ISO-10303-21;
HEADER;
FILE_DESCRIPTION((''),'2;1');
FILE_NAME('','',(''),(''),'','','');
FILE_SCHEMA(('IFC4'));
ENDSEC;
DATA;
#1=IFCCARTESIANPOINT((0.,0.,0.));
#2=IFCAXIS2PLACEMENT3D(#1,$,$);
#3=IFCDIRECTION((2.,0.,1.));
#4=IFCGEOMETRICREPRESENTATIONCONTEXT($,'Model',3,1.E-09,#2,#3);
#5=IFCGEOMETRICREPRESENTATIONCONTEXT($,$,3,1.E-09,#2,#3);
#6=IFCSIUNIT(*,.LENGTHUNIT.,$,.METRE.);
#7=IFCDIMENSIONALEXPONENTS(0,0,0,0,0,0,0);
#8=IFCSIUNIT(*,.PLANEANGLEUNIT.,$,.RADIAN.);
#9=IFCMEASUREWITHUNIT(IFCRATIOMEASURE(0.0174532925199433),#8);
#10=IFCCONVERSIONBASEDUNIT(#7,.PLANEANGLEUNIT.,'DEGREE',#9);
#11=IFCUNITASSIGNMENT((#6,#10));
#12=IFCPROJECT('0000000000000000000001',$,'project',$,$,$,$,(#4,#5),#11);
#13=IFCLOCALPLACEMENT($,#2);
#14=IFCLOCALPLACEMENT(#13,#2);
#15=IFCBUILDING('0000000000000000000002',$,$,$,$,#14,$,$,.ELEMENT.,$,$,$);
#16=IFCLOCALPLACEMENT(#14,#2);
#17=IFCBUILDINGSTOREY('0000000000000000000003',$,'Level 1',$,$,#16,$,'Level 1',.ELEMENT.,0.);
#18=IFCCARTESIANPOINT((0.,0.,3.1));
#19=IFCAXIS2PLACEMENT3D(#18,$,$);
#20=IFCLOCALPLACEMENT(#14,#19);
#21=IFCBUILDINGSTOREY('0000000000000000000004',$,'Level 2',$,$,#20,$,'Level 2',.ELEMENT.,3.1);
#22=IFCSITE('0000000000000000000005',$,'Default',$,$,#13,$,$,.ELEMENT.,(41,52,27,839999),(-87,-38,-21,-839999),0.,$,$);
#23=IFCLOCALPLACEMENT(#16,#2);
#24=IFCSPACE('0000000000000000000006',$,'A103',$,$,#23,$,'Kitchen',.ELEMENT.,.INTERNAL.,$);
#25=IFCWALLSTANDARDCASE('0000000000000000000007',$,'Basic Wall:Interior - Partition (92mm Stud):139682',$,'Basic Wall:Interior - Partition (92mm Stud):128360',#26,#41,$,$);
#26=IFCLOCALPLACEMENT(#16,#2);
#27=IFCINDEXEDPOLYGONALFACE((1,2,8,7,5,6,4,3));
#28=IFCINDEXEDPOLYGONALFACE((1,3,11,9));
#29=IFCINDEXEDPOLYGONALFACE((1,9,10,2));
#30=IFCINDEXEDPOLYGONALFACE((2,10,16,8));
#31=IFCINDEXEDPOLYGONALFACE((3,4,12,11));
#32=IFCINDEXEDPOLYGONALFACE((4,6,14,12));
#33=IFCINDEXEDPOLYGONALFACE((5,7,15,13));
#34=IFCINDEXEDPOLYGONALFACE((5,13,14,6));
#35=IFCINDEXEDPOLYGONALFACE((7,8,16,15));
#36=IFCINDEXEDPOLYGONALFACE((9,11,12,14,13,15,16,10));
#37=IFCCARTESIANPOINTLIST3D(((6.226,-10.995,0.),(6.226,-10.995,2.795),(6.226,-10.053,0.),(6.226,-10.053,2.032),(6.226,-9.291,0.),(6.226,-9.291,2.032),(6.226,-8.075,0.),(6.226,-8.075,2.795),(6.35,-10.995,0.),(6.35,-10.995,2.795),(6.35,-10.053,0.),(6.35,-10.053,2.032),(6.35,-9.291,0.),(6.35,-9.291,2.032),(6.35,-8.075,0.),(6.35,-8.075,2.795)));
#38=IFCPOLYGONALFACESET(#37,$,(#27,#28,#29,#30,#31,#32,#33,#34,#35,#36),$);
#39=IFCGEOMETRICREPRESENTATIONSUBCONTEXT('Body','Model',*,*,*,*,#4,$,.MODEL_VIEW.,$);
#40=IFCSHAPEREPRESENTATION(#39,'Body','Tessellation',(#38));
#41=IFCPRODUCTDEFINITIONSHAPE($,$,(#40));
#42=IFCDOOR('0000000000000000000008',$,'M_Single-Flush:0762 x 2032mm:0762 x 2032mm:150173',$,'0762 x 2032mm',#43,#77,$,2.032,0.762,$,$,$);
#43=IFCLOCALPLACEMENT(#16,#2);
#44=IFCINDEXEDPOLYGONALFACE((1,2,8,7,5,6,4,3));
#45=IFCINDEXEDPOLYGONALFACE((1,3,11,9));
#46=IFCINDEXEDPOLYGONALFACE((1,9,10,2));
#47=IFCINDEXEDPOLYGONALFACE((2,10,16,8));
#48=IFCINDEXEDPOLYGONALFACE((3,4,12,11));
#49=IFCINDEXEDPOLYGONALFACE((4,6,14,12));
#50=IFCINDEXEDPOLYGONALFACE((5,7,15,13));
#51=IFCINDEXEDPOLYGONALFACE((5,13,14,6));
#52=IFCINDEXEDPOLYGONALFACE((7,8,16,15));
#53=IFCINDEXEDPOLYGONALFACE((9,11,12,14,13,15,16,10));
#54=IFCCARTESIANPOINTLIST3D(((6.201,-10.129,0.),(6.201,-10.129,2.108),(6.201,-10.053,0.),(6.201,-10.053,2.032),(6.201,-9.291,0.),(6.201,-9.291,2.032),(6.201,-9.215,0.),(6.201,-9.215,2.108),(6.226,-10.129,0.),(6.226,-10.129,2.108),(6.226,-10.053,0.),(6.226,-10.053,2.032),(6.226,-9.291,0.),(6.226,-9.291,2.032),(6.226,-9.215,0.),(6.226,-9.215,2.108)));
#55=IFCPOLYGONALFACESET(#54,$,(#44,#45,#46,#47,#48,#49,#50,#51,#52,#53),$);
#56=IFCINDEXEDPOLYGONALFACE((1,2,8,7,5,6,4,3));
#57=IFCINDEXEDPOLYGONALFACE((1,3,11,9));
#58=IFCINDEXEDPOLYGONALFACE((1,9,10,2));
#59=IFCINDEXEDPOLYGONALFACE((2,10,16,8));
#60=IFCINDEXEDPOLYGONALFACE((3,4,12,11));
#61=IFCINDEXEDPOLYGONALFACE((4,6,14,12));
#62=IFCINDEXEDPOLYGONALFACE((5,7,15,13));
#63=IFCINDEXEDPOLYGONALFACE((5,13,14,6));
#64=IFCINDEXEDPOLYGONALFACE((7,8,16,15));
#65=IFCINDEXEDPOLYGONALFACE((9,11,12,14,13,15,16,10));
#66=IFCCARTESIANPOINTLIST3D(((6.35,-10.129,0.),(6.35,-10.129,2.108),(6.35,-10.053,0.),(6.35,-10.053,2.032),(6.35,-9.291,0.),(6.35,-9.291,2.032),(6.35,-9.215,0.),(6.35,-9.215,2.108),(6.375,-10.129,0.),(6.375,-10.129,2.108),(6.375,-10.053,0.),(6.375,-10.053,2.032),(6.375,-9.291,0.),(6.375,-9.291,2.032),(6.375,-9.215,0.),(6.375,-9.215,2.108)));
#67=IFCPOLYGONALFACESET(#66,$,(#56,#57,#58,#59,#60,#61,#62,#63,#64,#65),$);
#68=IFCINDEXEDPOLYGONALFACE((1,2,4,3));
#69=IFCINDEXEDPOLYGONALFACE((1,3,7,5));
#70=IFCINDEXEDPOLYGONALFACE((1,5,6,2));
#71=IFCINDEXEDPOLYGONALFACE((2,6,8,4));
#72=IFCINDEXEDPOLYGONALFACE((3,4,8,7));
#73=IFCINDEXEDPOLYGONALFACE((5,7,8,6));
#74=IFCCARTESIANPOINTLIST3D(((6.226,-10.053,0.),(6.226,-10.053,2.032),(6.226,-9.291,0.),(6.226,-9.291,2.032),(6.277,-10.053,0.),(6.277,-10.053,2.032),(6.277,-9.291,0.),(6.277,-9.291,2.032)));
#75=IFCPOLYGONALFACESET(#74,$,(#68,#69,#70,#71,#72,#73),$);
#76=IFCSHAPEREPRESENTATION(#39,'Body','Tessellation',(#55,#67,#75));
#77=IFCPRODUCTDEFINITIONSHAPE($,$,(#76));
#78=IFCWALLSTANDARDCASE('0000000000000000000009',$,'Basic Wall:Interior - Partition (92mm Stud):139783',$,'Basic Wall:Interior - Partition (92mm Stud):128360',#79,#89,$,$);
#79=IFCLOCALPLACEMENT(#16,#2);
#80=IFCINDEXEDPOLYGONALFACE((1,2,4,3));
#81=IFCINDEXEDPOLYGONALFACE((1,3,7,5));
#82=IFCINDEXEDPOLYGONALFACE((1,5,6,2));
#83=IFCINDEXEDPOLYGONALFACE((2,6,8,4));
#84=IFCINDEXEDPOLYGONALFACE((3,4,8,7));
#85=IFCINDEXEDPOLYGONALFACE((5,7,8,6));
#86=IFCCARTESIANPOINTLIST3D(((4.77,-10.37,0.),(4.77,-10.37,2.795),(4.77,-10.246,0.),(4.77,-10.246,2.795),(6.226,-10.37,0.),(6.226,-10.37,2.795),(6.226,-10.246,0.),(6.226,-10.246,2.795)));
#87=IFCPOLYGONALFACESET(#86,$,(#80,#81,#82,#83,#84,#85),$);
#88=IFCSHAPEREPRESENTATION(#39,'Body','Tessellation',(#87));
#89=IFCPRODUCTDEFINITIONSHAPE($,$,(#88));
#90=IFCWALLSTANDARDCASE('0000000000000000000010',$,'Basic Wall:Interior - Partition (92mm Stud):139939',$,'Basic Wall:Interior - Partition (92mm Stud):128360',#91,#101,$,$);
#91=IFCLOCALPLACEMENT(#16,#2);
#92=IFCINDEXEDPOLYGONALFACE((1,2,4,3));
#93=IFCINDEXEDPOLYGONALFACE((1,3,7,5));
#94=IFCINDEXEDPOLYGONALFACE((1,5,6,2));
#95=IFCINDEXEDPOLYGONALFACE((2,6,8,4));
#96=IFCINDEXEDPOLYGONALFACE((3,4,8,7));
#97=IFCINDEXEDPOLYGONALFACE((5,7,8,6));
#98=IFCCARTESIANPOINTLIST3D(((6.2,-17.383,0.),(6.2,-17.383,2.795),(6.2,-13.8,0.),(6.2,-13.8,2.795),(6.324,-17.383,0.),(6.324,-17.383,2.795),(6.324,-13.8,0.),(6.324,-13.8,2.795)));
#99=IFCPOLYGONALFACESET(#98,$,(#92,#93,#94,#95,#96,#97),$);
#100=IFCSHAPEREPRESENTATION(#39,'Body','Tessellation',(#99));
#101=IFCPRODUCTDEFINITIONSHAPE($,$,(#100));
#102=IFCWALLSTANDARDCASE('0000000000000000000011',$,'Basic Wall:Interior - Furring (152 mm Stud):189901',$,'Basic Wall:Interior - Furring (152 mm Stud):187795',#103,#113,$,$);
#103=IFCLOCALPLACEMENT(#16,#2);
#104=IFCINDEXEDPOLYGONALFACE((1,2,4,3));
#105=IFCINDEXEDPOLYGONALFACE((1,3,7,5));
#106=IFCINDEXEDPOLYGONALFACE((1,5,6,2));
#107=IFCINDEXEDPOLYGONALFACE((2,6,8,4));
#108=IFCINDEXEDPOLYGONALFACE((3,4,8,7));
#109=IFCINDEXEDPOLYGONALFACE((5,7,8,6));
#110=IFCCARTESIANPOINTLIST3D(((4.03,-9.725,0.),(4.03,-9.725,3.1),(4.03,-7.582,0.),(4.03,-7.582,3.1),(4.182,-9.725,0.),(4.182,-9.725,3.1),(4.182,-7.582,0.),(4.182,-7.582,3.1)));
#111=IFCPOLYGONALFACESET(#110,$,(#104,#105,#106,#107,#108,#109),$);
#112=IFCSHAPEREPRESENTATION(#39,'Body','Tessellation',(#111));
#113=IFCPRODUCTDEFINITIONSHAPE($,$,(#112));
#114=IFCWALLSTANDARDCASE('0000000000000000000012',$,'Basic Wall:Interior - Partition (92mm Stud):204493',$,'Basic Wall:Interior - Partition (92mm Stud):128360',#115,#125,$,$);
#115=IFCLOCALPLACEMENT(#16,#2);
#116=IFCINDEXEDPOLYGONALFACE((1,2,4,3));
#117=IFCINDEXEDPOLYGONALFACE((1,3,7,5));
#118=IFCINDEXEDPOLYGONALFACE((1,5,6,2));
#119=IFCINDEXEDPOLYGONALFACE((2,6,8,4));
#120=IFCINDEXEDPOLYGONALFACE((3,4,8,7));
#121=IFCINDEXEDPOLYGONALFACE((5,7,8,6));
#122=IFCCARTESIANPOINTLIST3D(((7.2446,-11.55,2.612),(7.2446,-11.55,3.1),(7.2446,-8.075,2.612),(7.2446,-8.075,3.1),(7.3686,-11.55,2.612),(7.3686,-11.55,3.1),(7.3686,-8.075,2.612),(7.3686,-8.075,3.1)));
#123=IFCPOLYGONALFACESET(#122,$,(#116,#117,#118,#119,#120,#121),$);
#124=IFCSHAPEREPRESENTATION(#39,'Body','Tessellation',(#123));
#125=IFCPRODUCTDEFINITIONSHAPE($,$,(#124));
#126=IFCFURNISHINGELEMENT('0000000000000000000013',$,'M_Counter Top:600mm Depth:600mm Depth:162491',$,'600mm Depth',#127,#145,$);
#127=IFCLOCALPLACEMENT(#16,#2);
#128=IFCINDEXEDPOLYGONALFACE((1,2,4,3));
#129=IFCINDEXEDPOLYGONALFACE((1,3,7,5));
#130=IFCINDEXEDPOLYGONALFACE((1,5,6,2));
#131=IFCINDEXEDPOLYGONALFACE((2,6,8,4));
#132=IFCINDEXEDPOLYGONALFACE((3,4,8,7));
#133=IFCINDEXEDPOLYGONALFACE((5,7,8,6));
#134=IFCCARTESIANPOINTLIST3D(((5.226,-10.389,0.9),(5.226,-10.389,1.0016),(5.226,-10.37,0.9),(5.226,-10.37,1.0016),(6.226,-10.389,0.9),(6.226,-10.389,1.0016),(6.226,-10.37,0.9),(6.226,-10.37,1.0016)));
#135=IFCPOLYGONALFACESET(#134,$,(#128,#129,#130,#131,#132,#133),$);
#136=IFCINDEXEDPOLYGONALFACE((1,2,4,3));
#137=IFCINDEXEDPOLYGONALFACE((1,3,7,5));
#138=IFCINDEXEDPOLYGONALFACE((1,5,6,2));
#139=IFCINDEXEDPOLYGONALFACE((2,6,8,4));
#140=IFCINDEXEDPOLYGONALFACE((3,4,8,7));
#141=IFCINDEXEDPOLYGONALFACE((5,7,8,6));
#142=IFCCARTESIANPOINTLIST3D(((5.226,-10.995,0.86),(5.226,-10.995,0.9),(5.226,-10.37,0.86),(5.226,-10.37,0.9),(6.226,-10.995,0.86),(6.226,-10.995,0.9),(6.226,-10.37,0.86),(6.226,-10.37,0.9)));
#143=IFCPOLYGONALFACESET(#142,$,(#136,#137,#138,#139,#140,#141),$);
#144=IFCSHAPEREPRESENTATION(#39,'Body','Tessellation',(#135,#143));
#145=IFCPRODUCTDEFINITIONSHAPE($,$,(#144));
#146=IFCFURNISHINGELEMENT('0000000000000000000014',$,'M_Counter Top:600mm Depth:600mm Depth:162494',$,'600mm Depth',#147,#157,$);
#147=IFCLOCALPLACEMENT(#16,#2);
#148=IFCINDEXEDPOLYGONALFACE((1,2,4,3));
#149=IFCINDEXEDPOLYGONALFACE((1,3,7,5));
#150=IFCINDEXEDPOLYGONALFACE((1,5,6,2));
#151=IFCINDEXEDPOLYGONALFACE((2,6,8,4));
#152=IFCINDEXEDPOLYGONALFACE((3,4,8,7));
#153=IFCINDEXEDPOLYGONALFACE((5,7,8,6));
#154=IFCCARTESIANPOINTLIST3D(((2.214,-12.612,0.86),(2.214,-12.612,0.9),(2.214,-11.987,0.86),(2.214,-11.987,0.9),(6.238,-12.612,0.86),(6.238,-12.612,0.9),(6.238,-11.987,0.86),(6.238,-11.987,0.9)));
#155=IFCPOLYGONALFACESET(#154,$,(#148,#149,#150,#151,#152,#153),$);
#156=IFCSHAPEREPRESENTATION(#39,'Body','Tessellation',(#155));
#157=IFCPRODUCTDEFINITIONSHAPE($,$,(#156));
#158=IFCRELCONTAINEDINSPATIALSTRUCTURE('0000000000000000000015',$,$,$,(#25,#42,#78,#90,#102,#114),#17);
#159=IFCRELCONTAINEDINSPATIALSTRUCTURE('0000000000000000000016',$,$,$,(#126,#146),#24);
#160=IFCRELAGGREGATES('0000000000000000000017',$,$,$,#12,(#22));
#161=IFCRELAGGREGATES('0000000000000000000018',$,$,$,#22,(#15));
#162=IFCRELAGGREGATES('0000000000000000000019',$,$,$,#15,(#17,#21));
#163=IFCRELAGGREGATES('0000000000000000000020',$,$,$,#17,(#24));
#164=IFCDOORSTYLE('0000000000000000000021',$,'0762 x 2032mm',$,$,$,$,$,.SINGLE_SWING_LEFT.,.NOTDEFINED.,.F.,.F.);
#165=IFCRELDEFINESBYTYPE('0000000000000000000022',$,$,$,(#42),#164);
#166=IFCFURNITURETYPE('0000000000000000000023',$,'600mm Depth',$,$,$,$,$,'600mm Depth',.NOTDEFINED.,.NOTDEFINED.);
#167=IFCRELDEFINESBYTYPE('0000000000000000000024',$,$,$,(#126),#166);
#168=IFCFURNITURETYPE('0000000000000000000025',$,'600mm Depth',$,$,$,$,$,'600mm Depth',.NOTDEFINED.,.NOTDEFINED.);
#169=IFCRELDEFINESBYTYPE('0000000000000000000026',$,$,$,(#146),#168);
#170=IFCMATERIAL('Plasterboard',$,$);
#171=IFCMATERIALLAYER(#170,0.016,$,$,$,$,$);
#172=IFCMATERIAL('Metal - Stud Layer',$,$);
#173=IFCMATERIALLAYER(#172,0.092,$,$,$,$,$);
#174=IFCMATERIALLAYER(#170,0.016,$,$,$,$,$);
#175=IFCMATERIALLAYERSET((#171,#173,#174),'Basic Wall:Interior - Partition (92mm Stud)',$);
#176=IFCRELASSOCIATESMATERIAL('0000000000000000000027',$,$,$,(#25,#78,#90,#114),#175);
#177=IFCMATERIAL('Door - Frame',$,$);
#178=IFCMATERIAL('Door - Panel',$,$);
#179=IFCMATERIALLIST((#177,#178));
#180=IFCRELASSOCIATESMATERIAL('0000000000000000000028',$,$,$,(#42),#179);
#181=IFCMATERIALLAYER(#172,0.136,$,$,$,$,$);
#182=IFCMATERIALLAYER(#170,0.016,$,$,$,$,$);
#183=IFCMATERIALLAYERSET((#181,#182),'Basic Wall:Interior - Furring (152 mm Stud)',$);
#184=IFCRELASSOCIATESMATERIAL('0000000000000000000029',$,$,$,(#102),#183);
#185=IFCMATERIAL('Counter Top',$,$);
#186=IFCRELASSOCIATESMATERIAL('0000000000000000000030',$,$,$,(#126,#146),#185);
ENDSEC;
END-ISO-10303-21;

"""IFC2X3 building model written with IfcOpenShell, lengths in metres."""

from ifc_helpers import new_model, entity, si_unit, converted_unit, direction, frame, frame_2d, origin, place, context, subcontext, project, spatial, polyline, rectangle, outline, extrude, source, transform, mapped, material, material_list, layer, layer_set, layer_usage, type_object, type_shapes, element, fill, save


model = new_model("IFC2X3")

# Units and contexts
model_context = context("Model", 3, precision=1e-09, world=origin(), true_north=direction((2.0, 0.0, 1.0)))
context_of_model = context(None, 3, precision=1e-09, world=origin(), true_north=direction((2.0, 0.0, 1.0)))
body_context = subcontext(model_context, "Body", "Model", "MODEL_VIEW")
ifc_project = project(units=[si_unit("LENGTHUNIT", "METRE"), converted_unit("PLANEANGLEUNIT", "DEGREE", entity("IfcRatioMeasure", 0.0174532925199433), si_unit("PLANEANGLEUNIT", "RADIAN"), dimensions=[0, 0, 0, 0, 0, 0, 0])], contexts=[model_context, context_of_model])

# Site, building, storey
site_placement = place(None, origin())
site = spatial("IfcSite", under=ifc_project, at=site_placement, Name="Default", CompositionType="ELEMENT", RefLatitude=(41, 52, 27, 839999), RefLongitude=(-87, -38, -21, -839999), RefElevation=0.0)
building_placement = place(site_placement, origin())
building = spatial("IfcBuilding", under=site, at=building_placement, CompositionType="ELEMENT")
storey_1_placement = place(building_placement, origin())
storey_1 = spatial("IfcBuildingStorey", under=building, at=storey_1_placement, Name="Level 1", LongName="Level 1", CompositionType="ELEMENT", Elevation=0.0)

# Shared definitions
ifc_material_1 = material(Name="Metal - Stud Layer")
ifc_material_2 = material(Name="Plasterboard")
ifc_material_3 = material(Name="Door - Frame")
ifc_material_4 = material(Name="Door - Panel")

# Wall, opening, door
ifc_layer_1 = layer(ifc_material_2, 0.016)
ifc_layer_2 = layer(ifc_material_1, 0.092)
ifc_layer_3 = layer(ifc_material_2, 0.016)
ifc_layer_set_1 = layer_set([ifc_layer_1, ifc_layer_2, ifc_layer_3], Name="Basic Wall:Interior - Partition (92mm Stud)")
ifc_layer_usage_1 = layer_usage(ifc_layer_set_1, "AXIS2", "NEGATIVE", 0.062)
wall_1_placement = place(storey_1_placement, frame((6.288, -10.995, 0.0), z_axis=(0.0, 0.0, 1.0), x_axis=(0.0, 1.0, 0.0)))
wall_1 = element("IfcWallStandardCase", 1, at=wall_1_placement, inside=storey_1, material=ifc_layer_usage_1, Name="Basic Wall:Interior - Partition (92mm Stud):139682", ObjectType="Basic Wall:Interior - Partition (92mm Stud):128360", context=body_context, shape_type="SweptSolid", body=[
    extrude(rectangle(XDim=2.92, YDim=0.124, at=frame_2d((1.46, 0.0), x_axis=(-1.0, 0.0))), origin(), (0.0, 0.0, 1.0), 2.795),
])
opening_1_placement = place(wall_1_placement, frame((0.942, -0.062, 0.0)))
opening_1 = element("IfcOpeningElement", 2, at=opening_1_placement, cuts=wall_1, ObjectType="Opening", context=body_context, shape_type="SweptSolid", body=[
    extrude(rectangle(XDim=0.762, YDim=2.032, at=frame_2d((1.016, 0.381), x_axis=(0.0, -1.0))), frame((0.0, 0.0, 0.0), z_axis=(0.0, 1.0, 0.0), x_axis=(0.0, 0.0, 1.0)), (0.0, 0.0, 1.0), 0.124),
])
ifc_material_list_1 = material_list([ifc_material_3, ifc_material_4])
door_style_1 = type_object("IfcDoorStyle", Name="0762 x 2032mm", ConstructionType="NOTDEFINED", OperationType="SINGLE_SWING_LEFT", ParameterTakesPrecedence=False, Sizeable=False)
shared_shape_1 = source(origin(), body_context, "Body", "SweptSolid", [
    extrude(outline(polyline([(-0.457, -1.073), (0.457, -1.073), (0.457, 1.035), (0.381, 1.035), (0.381, -0.997), (-0.381, -0.997), (-0.381, 1.035), (-0.457, 1.035), (-0.457, -1.073)])), frame((0.381, 0.149, 1.035), z_axis=(0.0, -1.0, 0.0), x_axis=(-1.0, 0.0, 0.0)), (0.0, 0.0, 1.0), 0.025),
    extrude(outline(polyline([(-1.073, -0.457), (1.035, -0.457), (1.035, -0.381), (-0.997, -0.381), (-0.997, 0.381), (1.035, 0.381), (1.035, 0.457), (-1.073, 0.457), (-1.073, -0.457)])), frame((0.381, 0.0, 1.035), z_axis=(0.0, -1.0, 0.0), x_axis=(0.0, 0.0, -1.0)), (0.0, 0.0, 1.0), 0.025),
    extrude(rectangle(XDim=0.762, YDim=0.051, at=frame_2d((0.0, 0.0), x_axis=(1.0, 0.0))), frame((0.381, 0.0985, 0.0)), (0.0, 0.0, 1.0), 2.032),
])
type_shapes(door_style_1, [shared_shape_1])
door_1_placement = place(opening_1_placement, origin())
door_1 = element("IfcDoor", 3, at=door_1_placement, inside=storey_1, type_object=door_style_1, material=ifc_material_list_1, Name="M_Single-Flush:0762 x 2032mm:0762 x 2032mm:150173", ObjectType="0762 x 2032mm", OverallHeight=2.032, OverallWidth=0.762, context=body_context, shape_type="MappedRepresentation", body=[
    mapped(shared_shape_1, transform((0.0, 0.0, 0.0), scale=1.0)),
])
fill(opening_1, door_1)

# Walls
ifc_layer_usage_2 = layer_usage(ifc_layer_set_1, "AXIS2", "NEGATIVE", 0.062)
wall_2_placement = place(storey_1_placement, frame((4.77, -10.308, 0.0)))
element("IfcWallStandardCase", 4, at=wall_2_placement, inside=storey_1, material=ifc_layer_usage_2, Name="Basic Wall:Interior - Partition (92mm Stud):139783", ObjectType="Basic Wall:Interior - Partition (92mm Stud):128360", context=body_context, shape_type="SweptSolid", body=[
    extrude(rectangle(XDim=1.456, YDim=0.124, at=frame_2d((0.728, 0.0), x_axis=(-1.0, 0.0))), origin(), (0.0, 0.0, 1.0), 2.795),
])
ifc_layer_usage_3 = layer_usage(ifc_layer_set_1, "AXIS2", "NEGATIVE", 0.062)
wall_3_placement = place(storey_1_placement, frame((6.262, -13.8, 0.0), z_axis=(0.0, 0.0, 1.0), x_axis=(0.0, -1.0, 0.0)))
element("IfcWallStandardCase", 5, at=wall_3_placement, inside=storey_1, material=ifc_layer_usage_3, Name="Basic Wall:Interior - Partition (92mm Stud):139939", ObjectType="Basic Wall:Interior - Partition (92mm Stud):128360", context=body_context, shape_type="SweptSolid", body=[
    extrude(rectangle(XDim=3.583, YDim=0.124, at=frame_2d((1.7915, 0.0), x_axis=(-1.0, 0.0))), origin(), (0.0, 0.0, 1.0), 2.795),
])

# Shared definitions
storey_2_placement = place(building_placement, frame((0.0, 0.0, 3.1)))
storey_2 = spatial("IfcBuildingStorey", under=building, at=storey_2_placement, Name="Level 2", LongName="Level 2", CompositionType="ELEMENT", Elevation=3.1)

# Walls
ifc_layer_4 = layer(ifc_material_1, 0.136)
ifc_layer_5 = layer(ifc_material_2, 0.016)
ifc_layer_set_2 = layer_set([ifc_layer_4, ifc_layer_5], Name="Basic Wall:Interior - Furring (152 mm Stud)")
ifc_layer_usage_4 = layer_usage(ifc_layer_set_2, "AXIS2", "POSITIVE", -0.076)
wall_4_placement = place(storey_1_placement, frame((4.106, -9.725, 0.0), z_axis=(0.0, 0.0, 1.0), x_axis=(0.0, 1.0, 0.0)))
element("IfcWallStandardCase", 6, at=wall_4_placement, inside=storey_1, material=ifc_layer_usage_4, Name="Basic Wall:Interior - Furring (152 mm Stud):189901", ObjectType="Basic Wall:Interior - Furring (152 mm Stud):187795", context=body_context, shape_type="SweptSolid", body=[
    extrude(rectangle(XDim=2.143, YDim=0.152, at=frame_2d((1.0715, 0.0), x_axis=(-1.0, 0.0))), origin(), (0.0, 0.0, 1.0), 3.1),
])
ifc_layer_usage_5 = layer_usage(ifc_layer_set_1, "AXIS2", "NEGATIVE", 0.062)
wall_5_placement = place(storey_1_placement, frame((7.3066, -11.55, 2.612), z_axis=(0.0, 0.0, 1.0), x_axis=(0.0, 1.0, 0.0)))
element("IfcWallStandardCase", 7, at=wall_5_placement, inside=storey_1, material=ifc_layer_usage_5, Name="Basic Wall:Interior - Partition (92mm Stud):204493", ObjectType="Basic Wall:Interior - Partition (92mm Stud):128360", context=body_context, shape_type="SweptSolid", body=[
    extrude(rectangle(XDim=3.475, YDim=0.124, at=frame_2d((1.7375, 0.0), x_axis=(-1.0, 0.0))), origin(), (0.0, 0.0, 1.0), 0.488),
])

# Shared definitions
space_1_placement = place(storey_1_placement, origin())
space_1 = spatial("IfcSpace", under=storey_1, at=space_1_placement, Name="A103", LongName="Kitchen", CompositionType="ELEMENT", InteriorOrExteriorSpace="INTERNAL")

# Furnishing elements
ifc_material_5 = material(Name="Counter Top")
furniture_type_1 = type_object("IfcFurnitureType", Name="600mm Depth", ElementType="600mm Depth", AssemblyPlace="NOTDEFINED")
shared_shape_2 = source(origin(), body_context, "Body", "SweptSolid", [
    extrude(rectangle(XDim=0.0191, YDim=1.0, at=frame_2d((0.0, 0.0), x_axis=(1.0, 0.0))), frame((-0.7005, -0.0095, 0.9), z_axis=(0.0, 0.0, 1.0), x_axis=(0.0, -1.0, 0.0)), (0.0, 0.0, 1.0), 0.1016),
    extrude(rectangle(XDim=1.0, YDim=0.625, at=frame_2d((0.0, 0.0), x_axis=(1.0, 0.0))), frame((-0.7005, -0.3125, 0.86), z_axis=(0.0, 0.0, 1.0), x_axis=(-1.0, 0.0, 0.0)), (0.0, 0.0, 1.0), 0.04),
])
type_shapes(furniture_type_1, [shared_shape_2])
furnishing_1_placement = place(space_1_placement, frame((6.4265, -10.37, 0.0)))
element("IfcFurnishingElement", 8, at=furnishing_1_placement, inside=space_1, type_object=furniture_type_1, material=ifc_material_5, Name="M_Counter Top:600mm Depth:600mm Depth:162491", ObjectType="600mm Depth", context=body_context, shape_type="MappedRepresentation", body=[
    mapped(shared_shape_2, transform((0.0, 0.0, 0.0), scale=1.0)),
])
furniture_type_2 = type_object("IfcFurnitureType", Name="600mm Depth", ElementType="600mm Depth", AssemblyPlace="NOTDEFINED")
shared_shape_3 = source(origin(), body_context, "Body", "SweptSolid", [
    extrude(rectangle(XDim=4.024, YDim=0.625, at=frame_2d((0.0, 0.0), x_axis=(1.0, 0.0))), frame((0.8115, -0.3125, 0.86), z_axis=(0.0, 0.0, 1.0), x_axis=(-1.0, 0.0, 0.0)), (0.0, 0.0, 1.0), 0.04),
])
type_shapes(furniture_type_2, [shared_shape_3])
furnishing_2_placement = place(space_1_placement, frame((5.0375, -12.612, 0.0), z_axis=(0.0, 0.0, 1.0), x_axis=(-1.0, 0.0, 0.0)))
element("IfcFurnishingElement", 9, at=furnishing_2_placement, inside=space_1, type_object=furniture_type_2, material=ifc_material_5, Name="M_Counter Top:600mm Depth:600mm Depth:162494", ObjectType="600mm Depth", context=body_context, shape_type="MappedRepresentation", body=[
    mapped(shared_shape_3, transform((0.0, 0.0, 0.0), scale=1.0)),
])

save(model, "model.ifc")
